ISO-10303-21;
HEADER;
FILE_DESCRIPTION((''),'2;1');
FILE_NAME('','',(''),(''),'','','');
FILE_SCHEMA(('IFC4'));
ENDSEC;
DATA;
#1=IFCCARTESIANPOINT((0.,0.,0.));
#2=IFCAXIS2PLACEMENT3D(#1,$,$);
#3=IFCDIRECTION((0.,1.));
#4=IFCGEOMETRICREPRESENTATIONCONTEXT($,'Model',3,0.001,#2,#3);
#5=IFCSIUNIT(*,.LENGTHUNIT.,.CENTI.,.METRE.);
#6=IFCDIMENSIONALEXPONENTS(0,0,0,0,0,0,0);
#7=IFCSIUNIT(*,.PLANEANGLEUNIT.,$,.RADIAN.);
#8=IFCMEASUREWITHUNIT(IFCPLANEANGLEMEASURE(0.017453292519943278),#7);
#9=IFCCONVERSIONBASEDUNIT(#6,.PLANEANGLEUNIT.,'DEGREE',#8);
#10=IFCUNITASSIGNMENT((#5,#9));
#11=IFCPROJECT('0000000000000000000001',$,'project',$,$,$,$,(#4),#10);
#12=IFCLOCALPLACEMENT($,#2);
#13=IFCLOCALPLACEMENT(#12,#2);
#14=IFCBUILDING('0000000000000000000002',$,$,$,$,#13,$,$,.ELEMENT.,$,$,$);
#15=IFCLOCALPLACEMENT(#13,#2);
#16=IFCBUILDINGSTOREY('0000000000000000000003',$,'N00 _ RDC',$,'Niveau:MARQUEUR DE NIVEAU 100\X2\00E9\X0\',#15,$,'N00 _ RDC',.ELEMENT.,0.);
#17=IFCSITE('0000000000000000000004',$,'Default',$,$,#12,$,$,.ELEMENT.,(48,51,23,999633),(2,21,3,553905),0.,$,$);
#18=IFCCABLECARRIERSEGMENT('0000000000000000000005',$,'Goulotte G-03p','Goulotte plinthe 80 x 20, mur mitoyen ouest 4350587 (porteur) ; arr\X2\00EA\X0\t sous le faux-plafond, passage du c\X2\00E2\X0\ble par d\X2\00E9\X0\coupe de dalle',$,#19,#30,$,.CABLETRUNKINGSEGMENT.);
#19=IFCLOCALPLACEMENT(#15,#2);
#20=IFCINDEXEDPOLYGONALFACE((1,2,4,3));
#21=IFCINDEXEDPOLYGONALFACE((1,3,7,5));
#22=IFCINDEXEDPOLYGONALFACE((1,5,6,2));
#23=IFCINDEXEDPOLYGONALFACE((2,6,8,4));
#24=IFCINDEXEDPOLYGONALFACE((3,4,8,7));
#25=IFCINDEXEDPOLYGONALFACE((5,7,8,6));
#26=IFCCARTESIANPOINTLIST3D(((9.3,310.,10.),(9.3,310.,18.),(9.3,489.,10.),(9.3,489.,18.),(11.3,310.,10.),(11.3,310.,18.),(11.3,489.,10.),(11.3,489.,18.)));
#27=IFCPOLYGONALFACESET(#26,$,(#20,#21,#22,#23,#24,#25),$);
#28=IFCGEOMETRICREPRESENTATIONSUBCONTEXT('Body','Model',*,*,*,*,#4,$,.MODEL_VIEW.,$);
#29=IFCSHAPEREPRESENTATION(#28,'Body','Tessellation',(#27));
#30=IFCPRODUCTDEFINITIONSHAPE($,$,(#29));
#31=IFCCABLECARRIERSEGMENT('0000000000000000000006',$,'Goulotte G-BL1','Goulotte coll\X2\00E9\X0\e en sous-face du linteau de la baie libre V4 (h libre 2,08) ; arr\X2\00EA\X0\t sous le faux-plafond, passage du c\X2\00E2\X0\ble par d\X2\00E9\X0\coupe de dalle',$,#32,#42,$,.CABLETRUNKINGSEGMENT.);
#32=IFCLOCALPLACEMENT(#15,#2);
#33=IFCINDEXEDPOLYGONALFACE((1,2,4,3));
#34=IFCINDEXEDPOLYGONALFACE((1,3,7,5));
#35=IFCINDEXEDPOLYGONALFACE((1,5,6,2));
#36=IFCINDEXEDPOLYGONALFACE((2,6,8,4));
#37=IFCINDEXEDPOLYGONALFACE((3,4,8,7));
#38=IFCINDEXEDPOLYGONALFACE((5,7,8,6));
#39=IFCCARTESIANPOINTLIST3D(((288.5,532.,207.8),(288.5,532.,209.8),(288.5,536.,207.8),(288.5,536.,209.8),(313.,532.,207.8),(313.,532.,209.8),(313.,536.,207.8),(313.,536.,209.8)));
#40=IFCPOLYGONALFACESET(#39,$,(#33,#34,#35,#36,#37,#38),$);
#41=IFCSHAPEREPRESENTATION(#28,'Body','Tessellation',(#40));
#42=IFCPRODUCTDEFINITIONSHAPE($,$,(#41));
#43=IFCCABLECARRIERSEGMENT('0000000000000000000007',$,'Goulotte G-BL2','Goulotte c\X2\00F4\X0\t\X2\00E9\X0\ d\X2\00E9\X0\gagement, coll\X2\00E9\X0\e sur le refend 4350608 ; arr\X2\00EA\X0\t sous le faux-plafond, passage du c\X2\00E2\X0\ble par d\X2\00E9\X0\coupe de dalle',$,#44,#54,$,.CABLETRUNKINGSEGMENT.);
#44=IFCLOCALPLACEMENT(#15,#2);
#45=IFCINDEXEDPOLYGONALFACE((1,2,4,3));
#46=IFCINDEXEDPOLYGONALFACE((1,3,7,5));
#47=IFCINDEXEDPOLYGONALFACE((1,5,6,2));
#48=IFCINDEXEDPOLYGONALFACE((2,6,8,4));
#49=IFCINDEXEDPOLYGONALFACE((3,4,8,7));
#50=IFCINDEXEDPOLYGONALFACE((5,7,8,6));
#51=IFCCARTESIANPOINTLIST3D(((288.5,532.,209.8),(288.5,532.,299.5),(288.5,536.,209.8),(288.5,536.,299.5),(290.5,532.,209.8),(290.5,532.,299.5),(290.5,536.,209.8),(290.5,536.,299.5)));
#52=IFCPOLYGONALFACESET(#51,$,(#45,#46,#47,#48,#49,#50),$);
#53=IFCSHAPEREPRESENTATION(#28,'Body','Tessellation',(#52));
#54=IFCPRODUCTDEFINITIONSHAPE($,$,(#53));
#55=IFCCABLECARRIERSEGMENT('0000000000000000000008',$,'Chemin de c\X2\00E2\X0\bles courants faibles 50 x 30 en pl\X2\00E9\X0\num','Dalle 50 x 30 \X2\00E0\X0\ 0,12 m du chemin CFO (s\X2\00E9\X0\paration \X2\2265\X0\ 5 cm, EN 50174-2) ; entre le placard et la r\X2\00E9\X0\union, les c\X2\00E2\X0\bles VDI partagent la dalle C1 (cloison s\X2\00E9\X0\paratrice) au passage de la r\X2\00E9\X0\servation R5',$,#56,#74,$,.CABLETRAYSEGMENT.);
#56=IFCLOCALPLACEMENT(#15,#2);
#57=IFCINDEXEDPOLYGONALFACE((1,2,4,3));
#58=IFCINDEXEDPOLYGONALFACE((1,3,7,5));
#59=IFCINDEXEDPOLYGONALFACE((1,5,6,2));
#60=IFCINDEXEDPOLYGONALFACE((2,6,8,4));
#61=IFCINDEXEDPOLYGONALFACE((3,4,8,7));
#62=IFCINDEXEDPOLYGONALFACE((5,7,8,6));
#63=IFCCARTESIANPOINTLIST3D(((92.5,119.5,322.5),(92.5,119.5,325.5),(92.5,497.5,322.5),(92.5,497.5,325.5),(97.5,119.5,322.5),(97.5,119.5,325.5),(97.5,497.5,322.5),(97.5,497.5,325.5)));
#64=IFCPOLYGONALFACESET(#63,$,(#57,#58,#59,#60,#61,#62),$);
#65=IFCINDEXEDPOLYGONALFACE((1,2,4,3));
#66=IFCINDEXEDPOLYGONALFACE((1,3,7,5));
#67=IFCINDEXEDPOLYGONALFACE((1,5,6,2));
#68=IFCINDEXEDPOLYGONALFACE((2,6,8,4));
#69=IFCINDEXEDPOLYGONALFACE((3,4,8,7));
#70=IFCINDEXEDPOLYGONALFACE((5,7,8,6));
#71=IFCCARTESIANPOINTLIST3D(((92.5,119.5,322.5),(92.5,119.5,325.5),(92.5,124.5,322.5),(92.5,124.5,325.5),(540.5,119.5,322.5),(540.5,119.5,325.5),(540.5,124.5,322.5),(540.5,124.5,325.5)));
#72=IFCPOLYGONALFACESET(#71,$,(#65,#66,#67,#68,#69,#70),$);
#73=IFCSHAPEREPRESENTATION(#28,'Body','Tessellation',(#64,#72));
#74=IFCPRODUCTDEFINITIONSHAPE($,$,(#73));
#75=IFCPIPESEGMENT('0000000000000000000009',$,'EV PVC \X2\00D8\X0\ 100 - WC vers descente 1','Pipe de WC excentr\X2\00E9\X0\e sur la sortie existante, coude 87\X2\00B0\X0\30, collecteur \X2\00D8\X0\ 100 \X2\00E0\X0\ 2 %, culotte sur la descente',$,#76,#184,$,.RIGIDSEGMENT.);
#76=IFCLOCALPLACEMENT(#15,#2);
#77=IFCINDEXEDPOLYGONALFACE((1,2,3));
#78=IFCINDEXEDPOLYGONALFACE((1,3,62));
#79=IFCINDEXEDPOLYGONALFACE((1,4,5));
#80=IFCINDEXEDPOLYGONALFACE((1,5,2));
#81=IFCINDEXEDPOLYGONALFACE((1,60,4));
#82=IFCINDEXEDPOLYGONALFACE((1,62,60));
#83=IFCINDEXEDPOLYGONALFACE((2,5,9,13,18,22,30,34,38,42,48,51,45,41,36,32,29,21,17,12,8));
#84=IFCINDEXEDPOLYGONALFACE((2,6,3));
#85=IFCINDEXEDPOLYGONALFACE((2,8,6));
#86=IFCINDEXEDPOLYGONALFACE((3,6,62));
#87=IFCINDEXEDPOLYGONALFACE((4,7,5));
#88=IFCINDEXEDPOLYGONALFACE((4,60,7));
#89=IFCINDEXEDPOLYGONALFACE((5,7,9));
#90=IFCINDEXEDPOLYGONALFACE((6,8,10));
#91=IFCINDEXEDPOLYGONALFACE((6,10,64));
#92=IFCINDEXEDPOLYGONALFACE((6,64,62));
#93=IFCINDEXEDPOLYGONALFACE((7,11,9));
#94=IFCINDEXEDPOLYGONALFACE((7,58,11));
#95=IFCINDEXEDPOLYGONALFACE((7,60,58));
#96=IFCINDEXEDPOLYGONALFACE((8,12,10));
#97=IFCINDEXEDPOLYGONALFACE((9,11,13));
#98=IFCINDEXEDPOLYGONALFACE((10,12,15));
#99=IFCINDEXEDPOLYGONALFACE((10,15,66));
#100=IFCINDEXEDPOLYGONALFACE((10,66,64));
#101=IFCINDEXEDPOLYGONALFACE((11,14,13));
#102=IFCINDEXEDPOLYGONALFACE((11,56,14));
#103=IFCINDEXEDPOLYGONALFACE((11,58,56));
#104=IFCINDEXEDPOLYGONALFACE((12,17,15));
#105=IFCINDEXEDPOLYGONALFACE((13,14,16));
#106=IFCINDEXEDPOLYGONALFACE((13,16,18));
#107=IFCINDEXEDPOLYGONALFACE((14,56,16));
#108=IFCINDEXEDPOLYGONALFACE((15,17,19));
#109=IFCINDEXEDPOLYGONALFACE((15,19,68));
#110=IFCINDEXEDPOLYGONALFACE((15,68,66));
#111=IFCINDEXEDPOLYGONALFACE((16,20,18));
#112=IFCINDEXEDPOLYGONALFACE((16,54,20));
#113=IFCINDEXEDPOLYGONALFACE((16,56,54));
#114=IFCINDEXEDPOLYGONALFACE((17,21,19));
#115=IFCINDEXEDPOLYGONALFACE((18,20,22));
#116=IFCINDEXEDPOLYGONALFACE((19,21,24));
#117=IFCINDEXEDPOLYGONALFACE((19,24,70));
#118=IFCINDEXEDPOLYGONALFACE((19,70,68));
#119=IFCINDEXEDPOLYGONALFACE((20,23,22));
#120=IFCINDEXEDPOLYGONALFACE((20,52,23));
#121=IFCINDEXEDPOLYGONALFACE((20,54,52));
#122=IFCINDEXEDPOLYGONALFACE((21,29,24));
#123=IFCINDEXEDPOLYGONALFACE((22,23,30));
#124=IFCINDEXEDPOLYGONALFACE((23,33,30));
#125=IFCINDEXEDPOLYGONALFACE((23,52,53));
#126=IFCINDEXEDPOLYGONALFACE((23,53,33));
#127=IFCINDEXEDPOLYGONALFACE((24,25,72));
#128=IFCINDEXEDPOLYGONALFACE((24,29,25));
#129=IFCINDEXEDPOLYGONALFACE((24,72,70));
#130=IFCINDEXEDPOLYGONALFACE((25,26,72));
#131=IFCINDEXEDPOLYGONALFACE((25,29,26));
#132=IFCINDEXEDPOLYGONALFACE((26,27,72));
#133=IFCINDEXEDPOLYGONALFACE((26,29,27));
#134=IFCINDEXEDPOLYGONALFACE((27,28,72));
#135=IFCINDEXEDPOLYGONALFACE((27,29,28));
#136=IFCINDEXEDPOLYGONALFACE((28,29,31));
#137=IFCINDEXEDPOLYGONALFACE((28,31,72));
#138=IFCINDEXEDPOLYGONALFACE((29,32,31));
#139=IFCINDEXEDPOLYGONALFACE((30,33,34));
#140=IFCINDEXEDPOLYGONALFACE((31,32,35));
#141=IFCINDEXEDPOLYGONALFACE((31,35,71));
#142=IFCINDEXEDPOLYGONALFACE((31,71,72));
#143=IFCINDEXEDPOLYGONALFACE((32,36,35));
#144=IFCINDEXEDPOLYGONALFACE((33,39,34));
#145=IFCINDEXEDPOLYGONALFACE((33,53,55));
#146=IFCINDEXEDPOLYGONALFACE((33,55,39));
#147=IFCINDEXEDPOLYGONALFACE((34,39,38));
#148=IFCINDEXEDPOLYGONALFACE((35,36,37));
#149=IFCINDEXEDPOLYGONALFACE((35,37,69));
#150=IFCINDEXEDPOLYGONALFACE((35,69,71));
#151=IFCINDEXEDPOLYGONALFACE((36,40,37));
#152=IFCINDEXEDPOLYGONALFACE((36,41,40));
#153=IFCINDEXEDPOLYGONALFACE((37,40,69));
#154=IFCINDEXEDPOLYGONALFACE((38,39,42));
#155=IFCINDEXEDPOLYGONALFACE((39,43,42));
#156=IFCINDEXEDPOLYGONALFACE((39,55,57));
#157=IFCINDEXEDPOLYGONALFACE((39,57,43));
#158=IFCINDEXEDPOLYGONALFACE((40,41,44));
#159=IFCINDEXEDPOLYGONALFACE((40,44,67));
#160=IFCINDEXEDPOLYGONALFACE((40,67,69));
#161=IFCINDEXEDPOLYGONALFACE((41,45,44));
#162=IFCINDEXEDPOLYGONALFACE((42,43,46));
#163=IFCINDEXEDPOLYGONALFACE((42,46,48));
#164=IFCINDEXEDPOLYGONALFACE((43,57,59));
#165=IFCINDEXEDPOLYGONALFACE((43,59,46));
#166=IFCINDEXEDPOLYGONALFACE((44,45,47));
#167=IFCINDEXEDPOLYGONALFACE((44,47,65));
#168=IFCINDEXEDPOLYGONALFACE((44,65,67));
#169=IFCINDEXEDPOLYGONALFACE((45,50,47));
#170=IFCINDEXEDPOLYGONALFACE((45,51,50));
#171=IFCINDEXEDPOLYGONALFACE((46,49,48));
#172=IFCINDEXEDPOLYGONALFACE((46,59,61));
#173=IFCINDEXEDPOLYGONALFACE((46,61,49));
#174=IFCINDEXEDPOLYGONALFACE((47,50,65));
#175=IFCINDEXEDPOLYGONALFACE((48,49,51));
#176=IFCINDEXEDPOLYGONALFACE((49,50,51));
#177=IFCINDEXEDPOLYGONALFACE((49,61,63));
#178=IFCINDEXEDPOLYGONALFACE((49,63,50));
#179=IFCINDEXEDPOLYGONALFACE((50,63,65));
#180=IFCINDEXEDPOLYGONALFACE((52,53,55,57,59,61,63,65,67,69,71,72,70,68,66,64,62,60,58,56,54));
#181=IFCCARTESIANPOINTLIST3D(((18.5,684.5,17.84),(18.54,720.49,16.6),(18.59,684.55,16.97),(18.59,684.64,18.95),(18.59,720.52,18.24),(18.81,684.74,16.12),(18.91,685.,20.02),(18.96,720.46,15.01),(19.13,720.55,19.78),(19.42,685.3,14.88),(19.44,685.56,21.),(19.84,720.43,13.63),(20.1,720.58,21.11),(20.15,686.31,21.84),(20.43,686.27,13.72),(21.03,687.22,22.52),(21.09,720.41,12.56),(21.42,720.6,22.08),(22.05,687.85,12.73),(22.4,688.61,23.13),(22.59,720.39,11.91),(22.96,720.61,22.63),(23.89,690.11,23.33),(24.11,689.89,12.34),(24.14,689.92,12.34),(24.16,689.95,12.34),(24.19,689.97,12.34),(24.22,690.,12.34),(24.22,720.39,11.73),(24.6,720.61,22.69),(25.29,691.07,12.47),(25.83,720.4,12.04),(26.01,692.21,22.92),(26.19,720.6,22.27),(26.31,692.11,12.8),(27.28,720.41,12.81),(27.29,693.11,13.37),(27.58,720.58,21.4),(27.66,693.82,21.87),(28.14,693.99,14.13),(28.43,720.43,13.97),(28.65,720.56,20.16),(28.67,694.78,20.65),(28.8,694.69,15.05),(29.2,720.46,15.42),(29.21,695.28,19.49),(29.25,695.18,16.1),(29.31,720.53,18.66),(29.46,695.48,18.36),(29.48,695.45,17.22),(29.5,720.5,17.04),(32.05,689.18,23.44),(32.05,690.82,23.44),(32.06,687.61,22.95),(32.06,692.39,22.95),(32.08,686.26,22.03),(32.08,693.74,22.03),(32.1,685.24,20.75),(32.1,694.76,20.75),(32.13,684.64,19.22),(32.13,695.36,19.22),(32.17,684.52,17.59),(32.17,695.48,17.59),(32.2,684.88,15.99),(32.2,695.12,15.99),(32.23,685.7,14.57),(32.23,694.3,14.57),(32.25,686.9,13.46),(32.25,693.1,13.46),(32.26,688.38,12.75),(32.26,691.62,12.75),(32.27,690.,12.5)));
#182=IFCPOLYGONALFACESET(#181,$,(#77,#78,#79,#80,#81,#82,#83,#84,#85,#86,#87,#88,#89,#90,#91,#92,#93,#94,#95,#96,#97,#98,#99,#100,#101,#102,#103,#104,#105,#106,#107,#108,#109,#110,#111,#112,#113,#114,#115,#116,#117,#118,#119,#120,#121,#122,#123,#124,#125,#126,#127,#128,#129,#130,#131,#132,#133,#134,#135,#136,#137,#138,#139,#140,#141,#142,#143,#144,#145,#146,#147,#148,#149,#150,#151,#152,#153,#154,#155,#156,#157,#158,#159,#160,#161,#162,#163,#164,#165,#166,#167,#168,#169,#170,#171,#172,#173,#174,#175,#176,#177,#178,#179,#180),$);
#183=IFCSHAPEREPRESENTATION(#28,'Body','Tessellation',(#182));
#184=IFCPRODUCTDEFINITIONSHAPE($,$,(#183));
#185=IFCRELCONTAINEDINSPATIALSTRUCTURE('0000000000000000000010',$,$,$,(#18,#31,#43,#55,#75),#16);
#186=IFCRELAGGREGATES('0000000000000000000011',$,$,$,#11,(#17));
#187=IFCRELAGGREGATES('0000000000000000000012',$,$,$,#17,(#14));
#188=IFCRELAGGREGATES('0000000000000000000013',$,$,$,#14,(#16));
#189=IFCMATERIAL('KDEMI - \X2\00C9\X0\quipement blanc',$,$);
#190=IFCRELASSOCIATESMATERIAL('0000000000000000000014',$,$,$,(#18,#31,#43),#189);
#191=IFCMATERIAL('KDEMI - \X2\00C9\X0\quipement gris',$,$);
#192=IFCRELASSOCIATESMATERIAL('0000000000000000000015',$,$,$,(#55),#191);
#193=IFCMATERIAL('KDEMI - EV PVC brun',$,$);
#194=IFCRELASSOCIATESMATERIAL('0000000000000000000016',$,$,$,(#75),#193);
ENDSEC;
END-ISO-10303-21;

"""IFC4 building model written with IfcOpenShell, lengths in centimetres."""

from ifc_helpers import new_model, entity, si_unit, converted_unit, direction, frame, frame_2d, origin, origin_with_axes, place, context, subcontext, project, spatial, rectangle, extrude, material, element, save


model = new_model("IFC4")

# Units and contexts
model_context = context("Model", 3, precision=0.001, world=origin(), true_north=direction((0.0, 1.0)))
body_context = subcontext(model_context, "Body", "Model", "MODEL_VIEW")
ifc_project = project(units=[si_unit("LENGTHUNIT", "METRE", prefix="CENTI"), converted_unit("PLANEANGLEUNIT", "DEGREE", entity("IfcPlaneAngleMeasure", 0.017453292519943278), si_unit("PLANEANGLEUNIT", "RADIAN"), dimensions=[0, 0, 0, 0, 0, 0, 0])], contexts=[model_context])

# Site, building, storey
site_placement = place(None, origin())
site = spatial("IfcSite", under=ifc_project, at=site_placement, Name="Default", CompositionType="ELEMENT", RefLatitude=(48, 51, 23, 999633), RefLongitude=(2, 21, 3, 553905), RefElevation=0.0)
building_placement = place(site_placement, origin())
building = spatial("IfcBuilding", under=site, at=building_placement, CompositionType="ELEMENT")
storey_placement = place(building_placement, origin())
storey = spatial("IfcBuildingStorey", under=building, at=storey_placement, Name="N00 _ RDC", ObjectType="Niveau:MARQUEUR DE NIVEAU 100é", LongName="N00 _ RDC", CompositionType="ELEMENT", Elevation=0.0)

# Cable carrier segments
ifc_material_1 = material(Name="KDEMI - Équipement blanc")
cable_carrier_segment_1_placement = place(storey_placement, origin_with_axes())
element("IfcCableCarrierSegment", 1, at=cable_carrier_segment_1_placement, inside=storey, material=ifc_material_1, Name="Goulotte G-03p", Description="Goulotte plinthe 80 x 20, mur mitoyen ouest 4350587 (porteur) ; arrêt sous le faux-plafond, passage du câble par découpe de dalle", PredefinedType="CABLETRUNKINGSEGMENT", context=body_context, shape_type="SweptSolid", body=[
    extrude(rectangle(XDim=2.0, YDim=179.0, at=frame_2d((10.3, 399.5))), frame((0.0, 0.0, 10.0)), (0.0, 0.0, 1.0), 8.0),
])
cable_carrier_segment_2_placement = place(storey_placement, origin_with_axes())
element("IfcCableCarrierSegment", 2, at=cable_carrier_segment_2_placement, inside=storey, material=ifc_material_1, Name="Goulotte G-BL1", Description="Goulotte collée en sous-face du linteau de la baie libre V4 (h libre 2,08) ; arrêt sous le faux-plafond, passage du câble par découpe de dalle", PredefinedType="CABLETRUNKINGSEGMENT", context=body_context, shape_type="SweptSolid", body=[
    extrude(rectangle(XDim=24.5, YDim=4.0, at=frame_2d((300.75, 534.0))), frame((0.0, 0.0, 207.8)), (0.0, 0.0, 1.0), 2.0),
])
cable_carrier_segment_3_placement = place(storey_placement, origin_with_axes())
element("IfcCableCarrierSegment", 3, at=cable_carrier_segment_3_placement, inside=storey, material=ifc_material_1, Name="Goulotte G-BL2", Description="Goulotte côté dégagement, collée sur le refend 4350608 ; arrêt sous le faux-plafond, passage du câble par découpe de dalle", PredefinedType="CABLETRUNKINGSEGMENT", context=body_context, shape_type="SweptSolid", body=[
    extrude(rectangle(XDim=2.0, YDim=4.0, at=frame_2d((289.5, 534.0))), frame((0.0, 0.0, 209.8)), (0.0, 0.0, 1.0), 89.7),
])
ifc_material_2 = material(Name="KDEMI - Équipement gris")
cable_carrier_segment_4_placement = place(storey_placement, origin_with_axes())
element("IfcCableCarrierSegment", 4, at=cable_carrier_segment_4_placement, inside=storey, material=ifc_material_2, Name="Chemin de câbles courants faibles 50 x 30 en plénum", Description="Dalle 50 x 30 à 0,12 m du chemin CFO (séparation ≥ 5 cm, EN 50174-2) ; entre le placard et la réunion, les câbles VDI partagent la dalle C1 (cloison séparatrice) au passage de la réservation R5", PredefinedType="CABLETRAYSEGMENT", context=body_context, shape_type="SweptSolid", body=[
    extrude(rectangle(XDim=5.0, YDim=378.0, at=frame_2d((95.0, 308.5))), frame((0.0, 0.0, 322.5)), (0.0, 0.0, 1.0), 3.0),
    extrude(rectangle(XDim=448.0, YDim=5.0, at=frame_2d((316.5, 122.0))), frame((0.0, 0.0, 322.5)), (0.0, 0.0, 1.0), 3.0),
])

# Pipe segment
ifc_material_3 = material(Name="KDEMI - EV PVC brun")
pipe_segment_1_placement = place(storey_placement, origin_with_axes())
element("IfcPipeSegment", 5, at=pipe_segment_1_placement, inside=storey, material=ifc_material_3, Name="EV PVC Ø 100 - WC vers descente 1", Description="Pipe de WC excentrée sur la sortie existante, coude 87°30, collecteur Ø 100 à 2 %, culotte sur la descente", PredefinedType="RIGIDSEGMENT", context=body_context, shape_type="AdvancedSweptSolid", body=[
    entity("IfcSweptDiskSolid", entity("IfcPolyline", [entity("IfcCartesianPoint", [32.16, 690.0, 18.0]), entity("IfcCartesianPoint", [24.0, 690.0, 17.84]), entity("IfcCartesianPoint", [24.0, 720.5, 17.23])]), 5.5),
])

save(model, "model.ifc")
